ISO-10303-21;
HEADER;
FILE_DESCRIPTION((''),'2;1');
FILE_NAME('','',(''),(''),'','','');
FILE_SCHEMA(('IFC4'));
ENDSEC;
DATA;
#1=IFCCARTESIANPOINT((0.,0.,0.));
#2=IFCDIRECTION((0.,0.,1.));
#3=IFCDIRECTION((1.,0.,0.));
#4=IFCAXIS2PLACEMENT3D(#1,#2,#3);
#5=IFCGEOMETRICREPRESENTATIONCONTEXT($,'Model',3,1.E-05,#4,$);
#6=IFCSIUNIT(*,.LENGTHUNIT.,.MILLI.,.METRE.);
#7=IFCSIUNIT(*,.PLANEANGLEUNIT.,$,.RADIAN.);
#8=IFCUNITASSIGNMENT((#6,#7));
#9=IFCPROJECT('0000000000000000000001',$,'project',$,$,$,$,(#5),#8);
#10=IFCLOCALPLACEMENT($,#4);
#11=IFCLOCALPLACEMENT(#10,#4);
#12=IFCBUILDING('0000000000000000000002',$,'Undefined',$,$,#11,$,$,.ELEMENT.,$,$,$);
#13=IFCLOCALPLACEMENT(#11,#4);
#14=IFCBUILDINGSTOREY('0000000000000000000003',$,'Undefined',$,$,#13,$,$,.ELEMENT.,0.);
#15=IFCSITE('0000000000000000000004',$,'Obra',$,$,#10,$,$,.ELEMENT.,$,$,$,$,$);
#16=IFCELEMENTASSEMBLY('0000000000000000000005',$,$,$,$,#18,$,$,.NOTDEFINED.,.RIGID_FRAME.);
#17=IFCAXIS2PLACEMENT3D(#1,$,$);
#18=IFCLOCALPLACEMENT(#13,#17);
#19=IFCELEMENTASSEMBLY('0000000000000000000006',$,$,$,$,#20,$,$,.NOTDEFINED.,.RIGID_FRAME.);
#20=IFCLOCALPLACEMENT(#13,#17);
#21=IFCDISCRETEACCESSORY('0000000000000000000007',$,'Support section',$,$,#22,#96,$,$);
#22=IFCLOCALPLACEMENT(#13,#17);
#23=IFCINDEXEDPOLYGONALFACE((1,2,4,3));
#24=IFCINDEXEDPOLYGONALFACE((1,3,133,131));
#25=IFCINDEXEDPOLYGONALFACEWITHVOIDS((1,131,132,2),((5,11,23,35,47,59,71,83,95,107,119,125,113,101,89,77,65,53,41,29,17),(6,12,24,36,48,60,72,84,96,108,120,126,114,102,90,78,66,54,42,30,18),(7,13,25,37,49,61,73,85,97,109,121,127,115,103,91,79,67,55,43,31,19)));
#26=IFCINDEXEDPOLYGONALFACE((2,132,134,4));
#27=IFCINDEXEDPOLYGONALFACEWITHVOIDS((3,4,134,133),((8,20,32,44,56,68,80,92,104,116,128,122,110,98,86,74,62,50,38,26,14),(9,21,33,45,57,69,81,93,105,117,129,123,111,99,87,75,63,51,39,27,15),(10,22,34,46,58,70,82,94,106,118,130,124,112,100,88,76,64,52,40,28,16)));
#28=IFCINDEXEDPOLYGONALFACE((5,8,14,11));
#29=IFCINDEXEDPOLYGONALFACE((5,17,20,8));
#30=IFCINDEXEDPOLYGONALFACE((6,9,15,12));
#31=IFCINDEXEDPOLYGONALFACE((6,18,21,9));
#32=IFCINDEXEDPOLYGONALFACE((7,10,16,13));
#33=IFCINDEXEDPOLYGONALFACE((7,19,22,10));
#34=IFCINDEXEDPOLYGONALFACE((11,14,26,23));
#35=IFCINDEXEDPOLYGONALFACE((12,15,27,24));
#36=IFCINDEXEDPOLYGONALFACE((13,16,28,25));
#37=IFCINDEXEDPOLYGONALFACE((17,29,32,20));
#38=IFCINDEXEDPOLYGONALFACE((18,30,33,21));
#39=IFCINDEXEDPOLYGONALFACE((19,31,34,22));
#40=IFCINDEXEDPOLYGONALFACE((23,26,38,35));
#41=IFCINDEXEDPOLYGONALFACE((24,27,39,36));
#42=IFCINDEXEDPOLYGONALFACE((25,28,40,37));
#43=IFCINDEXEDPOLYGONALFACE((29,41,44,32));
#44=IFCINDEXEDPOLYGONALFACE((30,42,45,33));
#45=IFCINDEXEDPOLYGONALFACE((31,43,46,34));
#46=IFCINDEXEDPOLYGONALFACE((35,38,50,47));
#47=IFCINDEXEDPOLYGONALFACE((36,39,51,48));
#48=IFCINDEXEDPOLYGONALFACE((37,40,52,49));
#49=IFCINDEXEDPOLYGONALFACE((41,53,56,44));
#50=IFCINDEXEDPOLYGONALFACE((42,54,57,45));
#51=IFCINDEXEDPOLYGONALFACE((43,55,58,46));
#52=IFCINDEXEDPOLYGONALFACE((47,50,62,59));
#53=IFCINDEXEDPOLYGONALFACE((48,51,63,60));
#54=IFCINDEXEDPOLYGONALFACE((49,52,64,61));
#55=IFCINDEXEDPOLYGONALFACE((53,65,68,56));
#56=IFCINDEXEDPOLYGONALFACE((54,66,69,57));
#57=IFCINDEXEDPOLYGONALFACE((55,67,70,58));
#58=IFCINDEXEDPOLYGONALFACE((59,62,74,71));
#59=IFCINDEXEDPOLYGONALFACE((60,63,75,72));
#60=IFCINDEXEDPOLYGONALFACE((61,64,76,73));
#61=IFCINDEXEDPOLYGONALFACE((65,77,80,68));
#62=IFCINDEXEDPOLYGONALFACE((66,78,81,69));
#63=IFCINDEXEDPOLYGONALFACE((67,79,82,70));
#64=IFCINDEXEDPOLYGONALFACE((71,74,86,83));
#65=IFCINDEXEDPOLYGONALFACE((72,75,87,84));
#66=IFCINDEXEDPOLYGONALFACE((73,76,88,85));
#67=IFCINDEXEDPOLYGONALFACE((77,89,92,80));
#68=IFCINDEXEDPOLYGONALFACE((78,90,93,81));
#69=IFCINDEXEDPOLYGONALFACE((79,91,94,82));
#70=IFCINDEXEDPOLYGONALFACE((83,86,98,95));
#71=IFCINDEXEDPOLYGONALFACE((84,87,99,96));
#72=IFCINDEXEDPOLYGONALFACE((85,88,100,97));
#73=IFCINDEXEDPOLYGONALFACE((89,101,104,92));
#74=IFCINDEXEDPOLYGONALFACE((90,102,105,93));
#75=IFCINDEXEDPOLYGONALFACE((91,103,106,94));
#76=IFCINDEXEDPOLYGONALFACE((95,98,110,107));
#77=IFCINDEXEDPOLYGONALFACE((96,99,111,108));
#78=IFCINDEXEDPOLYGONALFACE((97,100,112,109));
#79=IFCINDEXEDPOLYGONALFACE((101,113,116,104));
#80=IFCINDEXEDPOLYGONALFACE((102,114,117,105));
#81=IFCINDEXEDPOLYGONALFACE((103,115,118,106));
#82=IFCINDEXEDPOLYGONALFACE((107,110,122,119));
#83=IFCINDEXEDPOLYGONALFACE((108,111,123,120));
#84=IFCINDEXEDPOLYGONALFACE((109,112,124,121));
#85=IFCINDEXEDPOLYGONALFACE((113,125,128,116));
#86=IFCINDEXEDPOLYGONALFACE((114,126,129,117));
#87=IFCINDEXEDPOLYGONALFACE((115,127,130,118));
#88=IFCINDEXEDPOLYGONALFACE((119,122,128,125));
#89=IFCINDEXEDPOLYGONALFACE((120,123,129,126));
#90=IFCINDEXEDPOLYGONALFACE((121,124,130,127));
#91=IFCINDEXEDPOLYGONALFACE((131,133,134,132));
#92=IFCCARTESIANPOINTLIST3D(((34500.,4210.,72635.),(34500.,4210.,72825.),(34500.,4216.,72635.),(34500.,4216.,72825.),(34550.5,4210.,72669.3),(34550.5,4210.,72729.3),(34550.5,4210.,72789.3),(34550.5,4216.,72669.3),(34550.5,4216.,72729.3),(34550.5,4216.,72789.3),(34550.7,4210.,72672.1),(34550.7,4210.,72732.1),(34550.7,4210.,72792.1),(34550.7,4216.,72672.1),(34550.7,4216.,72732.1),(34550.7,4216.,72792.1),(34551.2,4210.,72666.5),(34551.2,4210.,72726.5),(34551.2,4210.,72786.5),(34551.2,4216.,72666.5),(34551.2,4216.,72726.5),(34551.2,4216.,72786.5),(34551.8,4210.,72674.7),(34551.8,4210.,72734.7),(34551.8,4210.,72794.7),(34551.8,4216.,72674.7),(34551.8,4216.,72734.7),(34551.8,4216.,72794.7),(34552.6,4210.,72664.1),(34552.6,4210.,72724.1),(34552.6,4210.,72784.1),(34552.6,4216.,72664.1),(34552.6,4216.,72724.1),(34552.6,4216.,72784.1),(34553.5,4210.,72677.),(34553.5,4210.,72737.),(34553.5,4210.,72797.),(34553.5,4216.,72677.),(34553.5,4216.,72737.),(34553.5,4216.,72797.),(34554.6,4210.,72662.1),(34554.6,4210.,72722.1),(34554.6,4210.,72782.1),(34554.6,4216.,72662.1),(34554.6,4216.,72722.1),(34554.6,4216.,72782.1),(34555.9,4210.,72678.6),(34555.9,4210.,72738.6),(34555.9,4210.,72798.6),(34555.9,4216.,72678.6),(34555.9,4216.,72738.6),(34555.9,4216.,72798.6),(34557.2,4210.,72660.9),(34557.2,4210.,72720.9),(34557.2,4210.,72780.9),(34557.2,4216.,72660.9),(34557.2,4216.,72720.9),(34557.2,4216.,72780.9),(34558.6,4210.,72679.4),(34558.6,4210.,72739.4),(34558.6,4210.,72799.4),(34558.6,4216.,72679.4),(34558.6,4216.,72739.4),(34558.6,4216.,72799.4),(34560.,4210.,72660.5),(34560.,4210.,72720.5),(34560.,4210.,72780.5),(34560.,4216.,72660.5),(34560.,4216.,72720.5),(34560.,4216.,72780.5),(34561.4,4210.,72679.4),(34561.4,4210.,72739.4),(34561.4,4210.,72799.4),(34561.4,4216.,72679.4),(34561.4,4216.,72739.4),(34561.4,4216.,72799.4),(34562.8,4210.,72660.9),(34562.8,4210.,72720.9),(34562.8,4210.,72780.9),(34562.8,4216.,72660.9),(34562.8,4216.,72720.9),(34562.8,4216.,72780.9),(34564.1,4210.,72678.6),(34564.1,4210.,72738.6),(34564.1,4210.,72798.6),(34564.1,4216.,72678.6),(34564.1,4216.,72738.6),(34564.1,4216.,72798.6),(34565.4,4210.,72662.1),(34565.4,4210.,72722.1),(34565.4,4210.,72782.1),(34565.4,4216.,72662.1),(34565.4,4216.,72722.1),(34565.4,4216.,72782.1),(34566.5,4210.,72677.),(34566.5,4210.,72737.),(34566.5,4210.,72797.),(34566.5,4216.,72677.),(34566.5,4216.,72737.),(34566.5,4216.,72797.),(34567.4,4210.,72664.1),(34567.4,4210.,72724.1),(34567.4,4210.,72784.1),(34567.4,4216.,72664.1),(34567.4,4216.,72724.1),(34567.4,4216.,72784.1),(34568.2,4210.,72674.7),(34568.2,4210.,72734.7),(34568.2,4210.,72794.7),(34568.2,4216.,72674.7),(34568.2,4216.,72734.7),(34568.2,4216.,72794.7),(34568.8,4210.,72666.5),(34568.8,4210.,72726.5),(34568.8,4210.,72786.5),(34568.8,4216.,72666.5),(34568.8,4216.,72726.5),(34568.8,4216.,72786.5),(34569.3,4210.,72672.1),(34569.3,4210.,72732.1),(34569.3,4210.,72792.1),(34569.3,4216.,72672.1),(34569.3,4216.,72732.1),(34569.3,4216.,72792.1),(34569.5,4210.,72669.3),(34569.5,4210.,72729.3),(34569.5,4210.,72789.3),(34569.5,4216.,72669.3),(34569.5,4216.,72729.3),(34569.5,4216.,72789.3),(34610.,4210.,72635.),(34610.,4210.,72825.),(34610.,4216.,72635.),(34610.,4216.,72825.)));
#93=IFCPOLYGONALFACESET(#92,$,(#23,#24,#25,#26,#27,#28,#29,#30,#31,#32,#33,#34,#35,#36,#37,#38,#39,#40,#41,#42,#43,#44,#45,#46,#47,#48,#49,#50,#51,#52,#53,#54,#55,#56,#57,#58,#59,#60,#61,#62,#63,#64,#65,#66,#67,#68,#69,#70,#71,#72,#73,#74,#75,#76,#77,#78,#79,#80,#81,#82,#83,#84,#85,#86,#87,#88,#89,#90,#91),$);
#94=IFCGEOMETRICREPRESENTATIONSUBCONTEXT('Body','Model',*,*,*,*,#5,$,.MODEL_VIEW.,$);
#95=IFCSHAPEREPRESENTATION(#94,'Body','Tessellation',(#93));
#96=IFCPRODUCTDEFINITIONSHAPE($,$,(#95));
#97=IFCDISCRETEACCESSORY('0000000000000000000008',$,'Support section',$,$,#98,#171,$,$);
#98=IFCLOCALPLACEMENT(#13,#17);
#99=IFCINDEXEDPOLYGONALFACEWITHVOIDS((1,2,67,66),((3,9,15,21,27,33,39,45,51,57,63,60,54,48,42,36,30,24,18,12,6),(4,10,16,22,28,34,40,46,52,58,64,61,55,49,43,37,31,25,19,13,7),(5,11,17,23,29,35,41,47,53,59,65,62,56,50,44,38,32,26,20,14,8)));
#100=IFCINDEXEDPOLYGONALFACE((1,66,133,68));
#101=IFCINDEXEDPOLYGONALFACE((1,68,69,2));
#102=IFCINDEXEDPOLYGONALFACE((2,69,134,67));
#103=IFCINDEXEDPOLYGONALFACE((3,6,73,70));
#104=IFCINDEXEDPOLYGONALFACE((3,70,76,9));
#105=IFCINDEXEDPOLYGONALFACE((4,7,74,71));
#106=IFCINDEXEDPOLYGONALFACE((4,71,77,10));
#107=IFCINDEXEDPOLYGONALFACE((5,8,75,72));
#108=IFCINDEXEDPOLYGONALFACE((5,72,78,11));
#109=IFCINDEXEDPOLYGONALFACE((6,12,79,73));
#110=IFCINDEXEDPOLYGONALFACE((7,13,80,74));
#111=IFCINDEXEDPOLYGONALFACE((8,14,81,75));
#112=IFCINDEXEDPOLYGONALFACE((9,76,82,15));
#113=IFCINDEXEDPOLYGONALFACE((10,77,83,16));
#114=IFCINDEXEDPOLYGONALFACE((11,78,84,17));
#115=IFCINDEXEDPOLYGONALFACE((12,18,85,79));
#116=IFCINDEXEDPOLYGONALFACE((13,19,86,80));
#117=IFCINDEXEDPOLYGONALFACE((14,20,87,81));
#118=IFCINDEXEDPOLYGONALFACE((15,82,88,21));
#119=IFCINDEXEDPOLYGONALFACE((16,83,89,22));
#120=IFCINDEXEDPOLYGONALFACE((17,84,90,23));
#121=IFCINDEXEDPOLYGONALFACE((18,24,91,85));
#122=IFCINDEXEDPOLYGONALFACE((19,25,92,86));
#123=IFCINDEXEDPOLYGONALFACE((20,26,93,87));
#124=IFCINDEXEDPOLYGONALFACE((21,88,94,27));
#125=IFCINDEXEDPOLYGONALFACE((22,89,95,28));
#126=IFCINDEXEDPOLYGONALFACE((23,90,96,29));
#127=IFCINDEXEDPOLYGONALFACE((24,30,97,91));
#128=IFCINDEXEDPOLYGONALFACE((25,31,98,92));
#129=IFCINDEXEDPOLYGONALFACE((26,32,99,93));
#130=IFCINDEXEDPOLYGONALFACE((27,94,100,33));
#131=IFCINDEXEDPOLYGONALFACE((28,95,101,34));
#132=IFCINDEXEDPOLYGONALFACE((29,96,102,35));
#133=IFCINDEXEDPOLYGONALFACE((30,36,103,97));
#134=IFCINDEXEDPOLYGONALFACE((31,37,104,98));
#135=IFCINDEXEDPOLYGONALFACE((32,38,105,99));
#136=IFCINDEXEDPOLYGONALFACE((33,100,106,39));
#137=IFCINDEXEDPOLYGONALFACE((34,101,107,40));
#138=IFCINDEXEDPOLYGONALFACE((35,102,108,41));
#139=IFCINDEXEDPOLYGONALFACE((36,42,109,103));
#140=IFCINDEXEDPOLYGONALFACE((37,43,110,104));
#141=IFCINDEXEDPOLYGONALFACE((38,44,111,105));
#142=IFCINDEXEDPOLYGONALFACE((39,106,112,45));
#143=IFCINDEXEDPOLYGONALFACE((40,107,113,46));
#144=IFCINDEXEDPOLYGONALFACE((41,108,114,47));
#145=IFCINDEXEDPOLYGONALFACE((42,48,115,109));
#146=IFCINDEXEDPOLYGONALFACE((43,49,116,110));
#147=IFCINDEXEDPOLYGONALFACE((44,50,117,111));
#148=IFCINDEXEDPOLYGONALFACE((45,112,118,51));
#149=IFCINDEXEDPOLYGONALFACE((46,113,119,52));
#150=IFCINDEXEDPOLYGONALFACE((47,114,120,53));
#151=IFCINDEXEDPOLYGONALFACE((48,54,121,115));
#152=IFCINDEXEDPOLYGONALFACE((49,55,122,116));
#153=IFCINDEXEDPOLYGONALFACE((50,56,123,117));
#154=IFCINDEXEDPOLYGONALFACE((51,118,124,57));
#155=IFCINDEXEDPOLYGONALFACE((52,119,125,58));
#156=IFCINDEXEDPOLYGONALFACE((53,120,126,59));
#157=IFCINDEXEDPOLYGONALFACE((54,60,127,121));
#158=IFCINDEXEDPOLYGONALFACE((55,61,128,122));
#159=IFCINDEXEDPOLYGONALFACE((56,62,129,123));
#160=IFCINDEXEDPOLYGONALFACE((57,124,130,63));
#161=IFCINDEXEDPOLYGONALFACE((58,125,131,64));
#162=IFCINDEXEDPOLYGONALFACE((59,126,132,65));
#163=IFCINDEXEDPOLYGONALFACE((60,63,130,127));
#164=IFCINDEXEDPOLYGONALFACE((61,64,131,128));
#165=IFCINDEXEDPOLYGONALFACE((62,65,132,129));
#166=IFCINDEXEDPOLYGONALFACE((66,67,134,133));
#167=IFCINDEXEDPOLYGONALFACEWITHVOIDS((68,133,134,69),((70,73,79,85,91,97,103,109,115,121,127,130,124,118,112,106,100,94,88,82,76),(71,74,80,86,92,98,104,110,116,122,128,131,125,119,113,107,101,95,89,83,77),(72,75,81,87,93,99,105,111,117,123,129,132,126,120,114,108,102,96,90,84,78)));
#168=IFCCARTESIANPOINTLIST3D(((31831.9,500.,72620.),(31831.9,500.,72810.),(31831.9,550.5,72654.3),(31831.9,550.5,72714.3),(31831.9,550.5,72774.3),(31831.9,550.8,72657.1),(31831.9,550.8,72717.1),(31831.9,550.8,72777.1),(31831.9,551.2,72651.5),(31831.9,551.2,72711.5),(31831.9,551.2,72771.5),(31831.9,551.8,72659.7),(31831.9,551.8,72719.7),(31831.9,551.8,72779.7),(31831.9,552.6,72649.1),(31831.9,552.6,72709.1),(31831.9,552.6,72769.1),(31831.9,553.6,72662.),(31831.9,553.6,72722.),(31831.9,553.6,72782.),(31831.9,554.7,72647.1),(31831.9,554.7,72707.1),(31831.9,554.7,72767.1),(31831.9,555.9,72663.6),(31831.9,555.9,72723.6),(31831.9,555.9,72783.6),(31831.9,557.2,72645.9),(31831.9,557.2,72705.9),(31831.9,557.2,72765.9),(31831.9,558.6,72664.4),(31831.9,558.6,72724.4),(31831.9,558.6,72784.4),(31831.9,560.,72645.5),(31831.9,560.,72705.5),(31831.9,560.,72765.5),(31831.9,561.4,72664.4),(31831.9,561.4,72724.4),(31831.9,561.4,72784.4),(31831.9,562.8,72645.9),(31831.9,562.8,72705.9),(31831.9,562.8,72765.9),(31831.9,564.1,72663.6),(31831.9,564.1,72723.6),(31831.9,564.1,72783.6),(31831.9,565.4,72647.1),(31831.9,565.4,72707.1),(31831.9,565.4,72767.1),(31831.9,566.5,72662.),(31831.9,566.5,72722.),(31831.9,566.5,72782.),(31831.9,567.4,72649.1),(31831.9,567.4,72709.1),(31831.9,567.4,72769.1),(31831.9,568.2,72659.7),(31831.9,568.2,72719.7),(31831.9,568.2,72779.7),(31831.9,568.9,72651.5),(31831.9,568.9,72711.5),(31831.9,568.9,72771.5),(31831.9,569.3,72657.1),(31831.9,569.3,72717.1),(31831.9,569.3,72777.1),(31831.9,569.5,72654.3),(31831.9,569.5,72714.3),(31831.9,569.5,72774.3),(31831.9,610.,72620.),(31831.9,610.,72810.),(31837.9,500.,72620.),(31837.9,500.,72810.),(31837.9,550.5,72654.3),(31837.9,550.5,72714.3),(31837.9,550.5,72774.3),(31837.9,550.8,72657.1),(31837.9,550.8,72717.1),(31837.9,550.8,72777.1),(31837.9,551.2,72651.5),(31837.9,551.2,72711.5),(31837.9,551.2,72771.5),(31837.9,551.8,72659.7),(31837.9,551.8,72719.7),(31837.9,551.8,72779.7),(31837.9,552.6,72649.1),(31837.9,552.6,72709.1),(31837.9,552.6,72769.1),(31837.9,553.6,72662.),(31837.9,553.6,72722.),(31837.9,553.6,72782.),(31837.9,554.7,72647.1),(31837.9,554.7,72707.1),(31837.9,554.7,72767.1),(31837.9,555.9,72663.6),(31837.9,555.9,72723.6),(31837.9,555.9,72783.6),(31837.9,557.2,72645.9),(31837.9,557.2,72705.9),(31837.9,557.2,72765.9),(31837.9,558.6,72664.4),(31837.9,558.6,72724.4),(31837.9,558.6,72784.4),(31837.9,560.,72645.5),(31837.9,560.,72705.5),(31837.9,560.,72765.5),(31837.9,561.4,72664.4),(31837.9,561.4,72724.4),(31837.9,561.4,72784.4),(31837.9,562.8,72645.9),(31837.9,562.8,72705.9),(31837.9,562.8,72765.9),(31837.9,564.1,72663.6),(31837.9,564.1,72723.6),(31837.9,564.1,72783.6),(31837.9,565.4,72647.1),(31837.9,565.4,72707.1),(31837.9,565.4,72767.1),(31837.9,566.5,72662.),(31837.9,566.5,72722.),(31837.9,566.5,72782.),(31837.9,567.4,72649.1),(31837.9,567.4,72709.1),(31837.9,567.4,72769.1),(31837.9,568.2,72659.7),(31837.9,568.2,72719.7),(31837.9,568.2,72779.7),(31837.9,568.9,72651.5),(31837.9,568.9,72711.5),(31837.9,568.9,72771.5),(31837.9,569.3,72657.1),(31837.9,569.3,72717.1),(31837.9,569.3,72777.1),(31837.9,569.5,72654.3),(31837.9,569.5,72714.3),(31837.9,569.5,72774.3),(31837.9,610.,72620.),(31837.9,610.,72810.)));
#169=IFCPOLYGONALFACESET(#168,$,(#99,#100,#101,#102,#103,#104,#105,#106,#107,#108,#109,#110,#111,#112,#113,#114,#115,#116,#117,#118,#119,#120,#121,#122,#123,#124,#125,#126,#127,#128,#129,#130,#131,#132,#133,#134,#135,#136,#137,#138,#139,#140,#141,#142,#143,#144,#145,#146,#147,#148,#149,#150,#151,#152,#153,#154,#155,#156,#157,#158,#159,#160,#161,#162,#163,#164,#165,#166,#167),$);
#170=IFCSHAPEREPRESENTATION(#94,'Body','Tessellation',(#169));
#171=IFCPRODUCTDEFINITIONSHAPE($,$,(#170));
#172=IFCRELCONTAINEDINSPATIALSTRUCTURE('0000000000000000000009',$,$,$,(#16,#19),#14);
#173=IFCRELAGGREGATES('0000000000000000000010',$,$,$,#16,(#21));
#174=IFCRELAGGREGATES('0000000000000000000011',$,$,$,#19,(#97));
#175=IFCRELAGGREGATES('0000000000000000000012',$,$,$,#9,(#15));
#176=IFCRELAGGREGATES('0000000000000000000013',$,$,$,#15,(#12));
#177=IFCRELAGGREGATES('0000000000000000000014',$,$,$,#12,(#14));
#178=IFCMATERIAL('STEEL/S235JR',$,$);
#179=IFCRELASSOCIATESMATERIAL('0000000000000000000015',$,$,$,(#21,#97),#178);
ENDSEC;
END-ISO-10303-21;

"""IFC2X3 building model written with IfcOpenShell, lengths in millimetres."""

from ifc_helpers import new_model, si_unit, frame, origin_with_axes, origin_2d_with_axis, place, context, subcontext, project, spatial, rectangle, circle, extrude, source, transform, mapped, material, element, aggregate, save


model = new_model("IFC2X3")

# Units and contexts
model_context = context("Model", 3, precision=1e-05, world=origin_with_axes())
body_context = subcontext(model_context, "Body", "Model", "MODEL_VIEW")
ifc_project = project(units=[si_unit("LENGTHUNIT", "METRE", prefix="MILLI"), si_unit("PLANEANGLEUNIT", "RADIAN")], contexts=[model_context])

# Site, building, storey
site_placement = place(None, origin_with_axes())
site = spatial("IfcSite", under=ifc_project, at=site_placement, Name="Obra", CompositionType="ELEMENT")
building_placement = place(site_placement, origin_with_axes())
building = spatial("IfcBuilding", under=site, at=building_placement, Name="Undefined", CompositionType="ELEMENT")
storey_placement = place(building_placement, origin_with_axes())
storey = spatial("IfcBuildingStorey", under=building, at=storey_placement, Name="Undefined", CompositionType="ELEMENT", Elevation=0.0)

# Element assemblies
ifc_material_1 = material(Name="STEEL/S235JR")
assembly_1_placement = place(storey_placement, origin_with_axes())
assembly_1 = element("IfcElementAssembly", 1, at=assembly_1_placement, inside=storey, AssemblyPlace="NOTDEFINED", PredefinedType="RIGID_FRAME")
assembly_2_placement = place(storey_placement, origin_with_axes())
assembly_2 = element("IfcElementAssembly", 2, at=assembly_2_placement, inside=storey, AssemblyPlace="NOTDEFINED", PredefinedType="RIGID_FRAME")

# Discrete accessories, openings
shared_shape_1 = source(origin_with_axes(), body_context, "Body", "SweptSolid", [
    extrude(circle(Radius=9.5, at=origin_2d_with_axis()), frame((0.0, -9.2, 0.0), z_axis=(0.0, 1.0, 0.0), x_axis=(1.0, 0.0, 0.0)), (0.0, 0.0, 1.0), 6.2),
])
discrete_accessory_1_placement = place(assembly_1_placement, frame((34555.0, 4213.0, 72635.0), z_axis=(0.0, 0.0, 1.0), x_axis=(-1.0, 0.0, 0.0)))
discrete_accessory_1 = element("IfcDiscreteAccessory", 3, at=discrete_accessory_1_placement, material=ifc_material_1, Name="Support section", context=body_context, shape_type="SweptSolid", body=[
    extrude(rectangle(XDim=6.0, YDim=110.0, at=origin_2d_with_axis()), frame((0.0, 0.0, 190.0), z_axis=(0.0, 0.0, -1.0), x_axis=(0.0, 1.0, 0.0)), (0.0, 0.0, 1.0), 190.0),
])
opening_1_placement = place(assembly_1_placement, frame((34510.0, 4219.1, 72850.0), z_axis=(1.0, 0.0, 0.0), x_axis=(0.0, 0.0, -1.0)))
element("IfcOpeningElement", 4, at=opening_1_placement, cuts=discrete_accessory_1, ObjectType="Opening", context=body_context, shape_type="MappedRepresentation", body=[
    mapped(shared_shape_1, transform((60.0, 0.0, 50.0))),
    mapped(shared_shape_1, transform((120.0, 0.0, 50.0))),
    mapped(shared_shape_1, transform((180.0, 0.0, 50.0))),
])
aggregate(assembly_1, [discrete_accessory_1])
discrete_accessory_2_placement = place(assembly_2_placement, frame((31834.9, 555.0, 72620.0), z_axis=(0.0, 0.0, 1.0), x_axis=(0.000002, -1.0, 0.0)))
discrete_accessory_2 = element("IfcDiscreteAccessory", 5, at=discrete_accessory_2_placement, material=ifc_material_1, Name="Support section", context=body_context, shape_type="SweptSolid", body=[
    extrude(rectangle(XDim=6.0, YDim=110.0, at=origin_2d_with_axis()), frame((0.0, 0.0, 190.0), z_axis=(0.0, 0.0, -1.0), x_axis=(0.0, 1.0, 0.0)), (0.0, 0.0, 1.0), 190.0),
])
opening_2_placement = place(assembly_2_placement, frame((31828.8, 510.0, 72835.0), z_axis=(-0.000002, 1.0, 0.0), x_axis=(0.0, 0.0, -1.0)))
element("IfcOpeningElement", 6, at=opening_2_placement, cuts=discrete_accessory_2, ObjectType="Opening", context=body_context, shape_type="MappedRepresentation", body=[
    mapped(shared_shape_1, transform((60.0, 0.0, 50.0))),
    mapped(shared_shape_1, transform((120.0, 0.0, 50.0))),
    mapped(shared_shape_1, transform((180.0, 0.0, 50.0))),
])
aggregate(assembly_2, [discrete_accessory_2])

save(model, "model.ifc")
